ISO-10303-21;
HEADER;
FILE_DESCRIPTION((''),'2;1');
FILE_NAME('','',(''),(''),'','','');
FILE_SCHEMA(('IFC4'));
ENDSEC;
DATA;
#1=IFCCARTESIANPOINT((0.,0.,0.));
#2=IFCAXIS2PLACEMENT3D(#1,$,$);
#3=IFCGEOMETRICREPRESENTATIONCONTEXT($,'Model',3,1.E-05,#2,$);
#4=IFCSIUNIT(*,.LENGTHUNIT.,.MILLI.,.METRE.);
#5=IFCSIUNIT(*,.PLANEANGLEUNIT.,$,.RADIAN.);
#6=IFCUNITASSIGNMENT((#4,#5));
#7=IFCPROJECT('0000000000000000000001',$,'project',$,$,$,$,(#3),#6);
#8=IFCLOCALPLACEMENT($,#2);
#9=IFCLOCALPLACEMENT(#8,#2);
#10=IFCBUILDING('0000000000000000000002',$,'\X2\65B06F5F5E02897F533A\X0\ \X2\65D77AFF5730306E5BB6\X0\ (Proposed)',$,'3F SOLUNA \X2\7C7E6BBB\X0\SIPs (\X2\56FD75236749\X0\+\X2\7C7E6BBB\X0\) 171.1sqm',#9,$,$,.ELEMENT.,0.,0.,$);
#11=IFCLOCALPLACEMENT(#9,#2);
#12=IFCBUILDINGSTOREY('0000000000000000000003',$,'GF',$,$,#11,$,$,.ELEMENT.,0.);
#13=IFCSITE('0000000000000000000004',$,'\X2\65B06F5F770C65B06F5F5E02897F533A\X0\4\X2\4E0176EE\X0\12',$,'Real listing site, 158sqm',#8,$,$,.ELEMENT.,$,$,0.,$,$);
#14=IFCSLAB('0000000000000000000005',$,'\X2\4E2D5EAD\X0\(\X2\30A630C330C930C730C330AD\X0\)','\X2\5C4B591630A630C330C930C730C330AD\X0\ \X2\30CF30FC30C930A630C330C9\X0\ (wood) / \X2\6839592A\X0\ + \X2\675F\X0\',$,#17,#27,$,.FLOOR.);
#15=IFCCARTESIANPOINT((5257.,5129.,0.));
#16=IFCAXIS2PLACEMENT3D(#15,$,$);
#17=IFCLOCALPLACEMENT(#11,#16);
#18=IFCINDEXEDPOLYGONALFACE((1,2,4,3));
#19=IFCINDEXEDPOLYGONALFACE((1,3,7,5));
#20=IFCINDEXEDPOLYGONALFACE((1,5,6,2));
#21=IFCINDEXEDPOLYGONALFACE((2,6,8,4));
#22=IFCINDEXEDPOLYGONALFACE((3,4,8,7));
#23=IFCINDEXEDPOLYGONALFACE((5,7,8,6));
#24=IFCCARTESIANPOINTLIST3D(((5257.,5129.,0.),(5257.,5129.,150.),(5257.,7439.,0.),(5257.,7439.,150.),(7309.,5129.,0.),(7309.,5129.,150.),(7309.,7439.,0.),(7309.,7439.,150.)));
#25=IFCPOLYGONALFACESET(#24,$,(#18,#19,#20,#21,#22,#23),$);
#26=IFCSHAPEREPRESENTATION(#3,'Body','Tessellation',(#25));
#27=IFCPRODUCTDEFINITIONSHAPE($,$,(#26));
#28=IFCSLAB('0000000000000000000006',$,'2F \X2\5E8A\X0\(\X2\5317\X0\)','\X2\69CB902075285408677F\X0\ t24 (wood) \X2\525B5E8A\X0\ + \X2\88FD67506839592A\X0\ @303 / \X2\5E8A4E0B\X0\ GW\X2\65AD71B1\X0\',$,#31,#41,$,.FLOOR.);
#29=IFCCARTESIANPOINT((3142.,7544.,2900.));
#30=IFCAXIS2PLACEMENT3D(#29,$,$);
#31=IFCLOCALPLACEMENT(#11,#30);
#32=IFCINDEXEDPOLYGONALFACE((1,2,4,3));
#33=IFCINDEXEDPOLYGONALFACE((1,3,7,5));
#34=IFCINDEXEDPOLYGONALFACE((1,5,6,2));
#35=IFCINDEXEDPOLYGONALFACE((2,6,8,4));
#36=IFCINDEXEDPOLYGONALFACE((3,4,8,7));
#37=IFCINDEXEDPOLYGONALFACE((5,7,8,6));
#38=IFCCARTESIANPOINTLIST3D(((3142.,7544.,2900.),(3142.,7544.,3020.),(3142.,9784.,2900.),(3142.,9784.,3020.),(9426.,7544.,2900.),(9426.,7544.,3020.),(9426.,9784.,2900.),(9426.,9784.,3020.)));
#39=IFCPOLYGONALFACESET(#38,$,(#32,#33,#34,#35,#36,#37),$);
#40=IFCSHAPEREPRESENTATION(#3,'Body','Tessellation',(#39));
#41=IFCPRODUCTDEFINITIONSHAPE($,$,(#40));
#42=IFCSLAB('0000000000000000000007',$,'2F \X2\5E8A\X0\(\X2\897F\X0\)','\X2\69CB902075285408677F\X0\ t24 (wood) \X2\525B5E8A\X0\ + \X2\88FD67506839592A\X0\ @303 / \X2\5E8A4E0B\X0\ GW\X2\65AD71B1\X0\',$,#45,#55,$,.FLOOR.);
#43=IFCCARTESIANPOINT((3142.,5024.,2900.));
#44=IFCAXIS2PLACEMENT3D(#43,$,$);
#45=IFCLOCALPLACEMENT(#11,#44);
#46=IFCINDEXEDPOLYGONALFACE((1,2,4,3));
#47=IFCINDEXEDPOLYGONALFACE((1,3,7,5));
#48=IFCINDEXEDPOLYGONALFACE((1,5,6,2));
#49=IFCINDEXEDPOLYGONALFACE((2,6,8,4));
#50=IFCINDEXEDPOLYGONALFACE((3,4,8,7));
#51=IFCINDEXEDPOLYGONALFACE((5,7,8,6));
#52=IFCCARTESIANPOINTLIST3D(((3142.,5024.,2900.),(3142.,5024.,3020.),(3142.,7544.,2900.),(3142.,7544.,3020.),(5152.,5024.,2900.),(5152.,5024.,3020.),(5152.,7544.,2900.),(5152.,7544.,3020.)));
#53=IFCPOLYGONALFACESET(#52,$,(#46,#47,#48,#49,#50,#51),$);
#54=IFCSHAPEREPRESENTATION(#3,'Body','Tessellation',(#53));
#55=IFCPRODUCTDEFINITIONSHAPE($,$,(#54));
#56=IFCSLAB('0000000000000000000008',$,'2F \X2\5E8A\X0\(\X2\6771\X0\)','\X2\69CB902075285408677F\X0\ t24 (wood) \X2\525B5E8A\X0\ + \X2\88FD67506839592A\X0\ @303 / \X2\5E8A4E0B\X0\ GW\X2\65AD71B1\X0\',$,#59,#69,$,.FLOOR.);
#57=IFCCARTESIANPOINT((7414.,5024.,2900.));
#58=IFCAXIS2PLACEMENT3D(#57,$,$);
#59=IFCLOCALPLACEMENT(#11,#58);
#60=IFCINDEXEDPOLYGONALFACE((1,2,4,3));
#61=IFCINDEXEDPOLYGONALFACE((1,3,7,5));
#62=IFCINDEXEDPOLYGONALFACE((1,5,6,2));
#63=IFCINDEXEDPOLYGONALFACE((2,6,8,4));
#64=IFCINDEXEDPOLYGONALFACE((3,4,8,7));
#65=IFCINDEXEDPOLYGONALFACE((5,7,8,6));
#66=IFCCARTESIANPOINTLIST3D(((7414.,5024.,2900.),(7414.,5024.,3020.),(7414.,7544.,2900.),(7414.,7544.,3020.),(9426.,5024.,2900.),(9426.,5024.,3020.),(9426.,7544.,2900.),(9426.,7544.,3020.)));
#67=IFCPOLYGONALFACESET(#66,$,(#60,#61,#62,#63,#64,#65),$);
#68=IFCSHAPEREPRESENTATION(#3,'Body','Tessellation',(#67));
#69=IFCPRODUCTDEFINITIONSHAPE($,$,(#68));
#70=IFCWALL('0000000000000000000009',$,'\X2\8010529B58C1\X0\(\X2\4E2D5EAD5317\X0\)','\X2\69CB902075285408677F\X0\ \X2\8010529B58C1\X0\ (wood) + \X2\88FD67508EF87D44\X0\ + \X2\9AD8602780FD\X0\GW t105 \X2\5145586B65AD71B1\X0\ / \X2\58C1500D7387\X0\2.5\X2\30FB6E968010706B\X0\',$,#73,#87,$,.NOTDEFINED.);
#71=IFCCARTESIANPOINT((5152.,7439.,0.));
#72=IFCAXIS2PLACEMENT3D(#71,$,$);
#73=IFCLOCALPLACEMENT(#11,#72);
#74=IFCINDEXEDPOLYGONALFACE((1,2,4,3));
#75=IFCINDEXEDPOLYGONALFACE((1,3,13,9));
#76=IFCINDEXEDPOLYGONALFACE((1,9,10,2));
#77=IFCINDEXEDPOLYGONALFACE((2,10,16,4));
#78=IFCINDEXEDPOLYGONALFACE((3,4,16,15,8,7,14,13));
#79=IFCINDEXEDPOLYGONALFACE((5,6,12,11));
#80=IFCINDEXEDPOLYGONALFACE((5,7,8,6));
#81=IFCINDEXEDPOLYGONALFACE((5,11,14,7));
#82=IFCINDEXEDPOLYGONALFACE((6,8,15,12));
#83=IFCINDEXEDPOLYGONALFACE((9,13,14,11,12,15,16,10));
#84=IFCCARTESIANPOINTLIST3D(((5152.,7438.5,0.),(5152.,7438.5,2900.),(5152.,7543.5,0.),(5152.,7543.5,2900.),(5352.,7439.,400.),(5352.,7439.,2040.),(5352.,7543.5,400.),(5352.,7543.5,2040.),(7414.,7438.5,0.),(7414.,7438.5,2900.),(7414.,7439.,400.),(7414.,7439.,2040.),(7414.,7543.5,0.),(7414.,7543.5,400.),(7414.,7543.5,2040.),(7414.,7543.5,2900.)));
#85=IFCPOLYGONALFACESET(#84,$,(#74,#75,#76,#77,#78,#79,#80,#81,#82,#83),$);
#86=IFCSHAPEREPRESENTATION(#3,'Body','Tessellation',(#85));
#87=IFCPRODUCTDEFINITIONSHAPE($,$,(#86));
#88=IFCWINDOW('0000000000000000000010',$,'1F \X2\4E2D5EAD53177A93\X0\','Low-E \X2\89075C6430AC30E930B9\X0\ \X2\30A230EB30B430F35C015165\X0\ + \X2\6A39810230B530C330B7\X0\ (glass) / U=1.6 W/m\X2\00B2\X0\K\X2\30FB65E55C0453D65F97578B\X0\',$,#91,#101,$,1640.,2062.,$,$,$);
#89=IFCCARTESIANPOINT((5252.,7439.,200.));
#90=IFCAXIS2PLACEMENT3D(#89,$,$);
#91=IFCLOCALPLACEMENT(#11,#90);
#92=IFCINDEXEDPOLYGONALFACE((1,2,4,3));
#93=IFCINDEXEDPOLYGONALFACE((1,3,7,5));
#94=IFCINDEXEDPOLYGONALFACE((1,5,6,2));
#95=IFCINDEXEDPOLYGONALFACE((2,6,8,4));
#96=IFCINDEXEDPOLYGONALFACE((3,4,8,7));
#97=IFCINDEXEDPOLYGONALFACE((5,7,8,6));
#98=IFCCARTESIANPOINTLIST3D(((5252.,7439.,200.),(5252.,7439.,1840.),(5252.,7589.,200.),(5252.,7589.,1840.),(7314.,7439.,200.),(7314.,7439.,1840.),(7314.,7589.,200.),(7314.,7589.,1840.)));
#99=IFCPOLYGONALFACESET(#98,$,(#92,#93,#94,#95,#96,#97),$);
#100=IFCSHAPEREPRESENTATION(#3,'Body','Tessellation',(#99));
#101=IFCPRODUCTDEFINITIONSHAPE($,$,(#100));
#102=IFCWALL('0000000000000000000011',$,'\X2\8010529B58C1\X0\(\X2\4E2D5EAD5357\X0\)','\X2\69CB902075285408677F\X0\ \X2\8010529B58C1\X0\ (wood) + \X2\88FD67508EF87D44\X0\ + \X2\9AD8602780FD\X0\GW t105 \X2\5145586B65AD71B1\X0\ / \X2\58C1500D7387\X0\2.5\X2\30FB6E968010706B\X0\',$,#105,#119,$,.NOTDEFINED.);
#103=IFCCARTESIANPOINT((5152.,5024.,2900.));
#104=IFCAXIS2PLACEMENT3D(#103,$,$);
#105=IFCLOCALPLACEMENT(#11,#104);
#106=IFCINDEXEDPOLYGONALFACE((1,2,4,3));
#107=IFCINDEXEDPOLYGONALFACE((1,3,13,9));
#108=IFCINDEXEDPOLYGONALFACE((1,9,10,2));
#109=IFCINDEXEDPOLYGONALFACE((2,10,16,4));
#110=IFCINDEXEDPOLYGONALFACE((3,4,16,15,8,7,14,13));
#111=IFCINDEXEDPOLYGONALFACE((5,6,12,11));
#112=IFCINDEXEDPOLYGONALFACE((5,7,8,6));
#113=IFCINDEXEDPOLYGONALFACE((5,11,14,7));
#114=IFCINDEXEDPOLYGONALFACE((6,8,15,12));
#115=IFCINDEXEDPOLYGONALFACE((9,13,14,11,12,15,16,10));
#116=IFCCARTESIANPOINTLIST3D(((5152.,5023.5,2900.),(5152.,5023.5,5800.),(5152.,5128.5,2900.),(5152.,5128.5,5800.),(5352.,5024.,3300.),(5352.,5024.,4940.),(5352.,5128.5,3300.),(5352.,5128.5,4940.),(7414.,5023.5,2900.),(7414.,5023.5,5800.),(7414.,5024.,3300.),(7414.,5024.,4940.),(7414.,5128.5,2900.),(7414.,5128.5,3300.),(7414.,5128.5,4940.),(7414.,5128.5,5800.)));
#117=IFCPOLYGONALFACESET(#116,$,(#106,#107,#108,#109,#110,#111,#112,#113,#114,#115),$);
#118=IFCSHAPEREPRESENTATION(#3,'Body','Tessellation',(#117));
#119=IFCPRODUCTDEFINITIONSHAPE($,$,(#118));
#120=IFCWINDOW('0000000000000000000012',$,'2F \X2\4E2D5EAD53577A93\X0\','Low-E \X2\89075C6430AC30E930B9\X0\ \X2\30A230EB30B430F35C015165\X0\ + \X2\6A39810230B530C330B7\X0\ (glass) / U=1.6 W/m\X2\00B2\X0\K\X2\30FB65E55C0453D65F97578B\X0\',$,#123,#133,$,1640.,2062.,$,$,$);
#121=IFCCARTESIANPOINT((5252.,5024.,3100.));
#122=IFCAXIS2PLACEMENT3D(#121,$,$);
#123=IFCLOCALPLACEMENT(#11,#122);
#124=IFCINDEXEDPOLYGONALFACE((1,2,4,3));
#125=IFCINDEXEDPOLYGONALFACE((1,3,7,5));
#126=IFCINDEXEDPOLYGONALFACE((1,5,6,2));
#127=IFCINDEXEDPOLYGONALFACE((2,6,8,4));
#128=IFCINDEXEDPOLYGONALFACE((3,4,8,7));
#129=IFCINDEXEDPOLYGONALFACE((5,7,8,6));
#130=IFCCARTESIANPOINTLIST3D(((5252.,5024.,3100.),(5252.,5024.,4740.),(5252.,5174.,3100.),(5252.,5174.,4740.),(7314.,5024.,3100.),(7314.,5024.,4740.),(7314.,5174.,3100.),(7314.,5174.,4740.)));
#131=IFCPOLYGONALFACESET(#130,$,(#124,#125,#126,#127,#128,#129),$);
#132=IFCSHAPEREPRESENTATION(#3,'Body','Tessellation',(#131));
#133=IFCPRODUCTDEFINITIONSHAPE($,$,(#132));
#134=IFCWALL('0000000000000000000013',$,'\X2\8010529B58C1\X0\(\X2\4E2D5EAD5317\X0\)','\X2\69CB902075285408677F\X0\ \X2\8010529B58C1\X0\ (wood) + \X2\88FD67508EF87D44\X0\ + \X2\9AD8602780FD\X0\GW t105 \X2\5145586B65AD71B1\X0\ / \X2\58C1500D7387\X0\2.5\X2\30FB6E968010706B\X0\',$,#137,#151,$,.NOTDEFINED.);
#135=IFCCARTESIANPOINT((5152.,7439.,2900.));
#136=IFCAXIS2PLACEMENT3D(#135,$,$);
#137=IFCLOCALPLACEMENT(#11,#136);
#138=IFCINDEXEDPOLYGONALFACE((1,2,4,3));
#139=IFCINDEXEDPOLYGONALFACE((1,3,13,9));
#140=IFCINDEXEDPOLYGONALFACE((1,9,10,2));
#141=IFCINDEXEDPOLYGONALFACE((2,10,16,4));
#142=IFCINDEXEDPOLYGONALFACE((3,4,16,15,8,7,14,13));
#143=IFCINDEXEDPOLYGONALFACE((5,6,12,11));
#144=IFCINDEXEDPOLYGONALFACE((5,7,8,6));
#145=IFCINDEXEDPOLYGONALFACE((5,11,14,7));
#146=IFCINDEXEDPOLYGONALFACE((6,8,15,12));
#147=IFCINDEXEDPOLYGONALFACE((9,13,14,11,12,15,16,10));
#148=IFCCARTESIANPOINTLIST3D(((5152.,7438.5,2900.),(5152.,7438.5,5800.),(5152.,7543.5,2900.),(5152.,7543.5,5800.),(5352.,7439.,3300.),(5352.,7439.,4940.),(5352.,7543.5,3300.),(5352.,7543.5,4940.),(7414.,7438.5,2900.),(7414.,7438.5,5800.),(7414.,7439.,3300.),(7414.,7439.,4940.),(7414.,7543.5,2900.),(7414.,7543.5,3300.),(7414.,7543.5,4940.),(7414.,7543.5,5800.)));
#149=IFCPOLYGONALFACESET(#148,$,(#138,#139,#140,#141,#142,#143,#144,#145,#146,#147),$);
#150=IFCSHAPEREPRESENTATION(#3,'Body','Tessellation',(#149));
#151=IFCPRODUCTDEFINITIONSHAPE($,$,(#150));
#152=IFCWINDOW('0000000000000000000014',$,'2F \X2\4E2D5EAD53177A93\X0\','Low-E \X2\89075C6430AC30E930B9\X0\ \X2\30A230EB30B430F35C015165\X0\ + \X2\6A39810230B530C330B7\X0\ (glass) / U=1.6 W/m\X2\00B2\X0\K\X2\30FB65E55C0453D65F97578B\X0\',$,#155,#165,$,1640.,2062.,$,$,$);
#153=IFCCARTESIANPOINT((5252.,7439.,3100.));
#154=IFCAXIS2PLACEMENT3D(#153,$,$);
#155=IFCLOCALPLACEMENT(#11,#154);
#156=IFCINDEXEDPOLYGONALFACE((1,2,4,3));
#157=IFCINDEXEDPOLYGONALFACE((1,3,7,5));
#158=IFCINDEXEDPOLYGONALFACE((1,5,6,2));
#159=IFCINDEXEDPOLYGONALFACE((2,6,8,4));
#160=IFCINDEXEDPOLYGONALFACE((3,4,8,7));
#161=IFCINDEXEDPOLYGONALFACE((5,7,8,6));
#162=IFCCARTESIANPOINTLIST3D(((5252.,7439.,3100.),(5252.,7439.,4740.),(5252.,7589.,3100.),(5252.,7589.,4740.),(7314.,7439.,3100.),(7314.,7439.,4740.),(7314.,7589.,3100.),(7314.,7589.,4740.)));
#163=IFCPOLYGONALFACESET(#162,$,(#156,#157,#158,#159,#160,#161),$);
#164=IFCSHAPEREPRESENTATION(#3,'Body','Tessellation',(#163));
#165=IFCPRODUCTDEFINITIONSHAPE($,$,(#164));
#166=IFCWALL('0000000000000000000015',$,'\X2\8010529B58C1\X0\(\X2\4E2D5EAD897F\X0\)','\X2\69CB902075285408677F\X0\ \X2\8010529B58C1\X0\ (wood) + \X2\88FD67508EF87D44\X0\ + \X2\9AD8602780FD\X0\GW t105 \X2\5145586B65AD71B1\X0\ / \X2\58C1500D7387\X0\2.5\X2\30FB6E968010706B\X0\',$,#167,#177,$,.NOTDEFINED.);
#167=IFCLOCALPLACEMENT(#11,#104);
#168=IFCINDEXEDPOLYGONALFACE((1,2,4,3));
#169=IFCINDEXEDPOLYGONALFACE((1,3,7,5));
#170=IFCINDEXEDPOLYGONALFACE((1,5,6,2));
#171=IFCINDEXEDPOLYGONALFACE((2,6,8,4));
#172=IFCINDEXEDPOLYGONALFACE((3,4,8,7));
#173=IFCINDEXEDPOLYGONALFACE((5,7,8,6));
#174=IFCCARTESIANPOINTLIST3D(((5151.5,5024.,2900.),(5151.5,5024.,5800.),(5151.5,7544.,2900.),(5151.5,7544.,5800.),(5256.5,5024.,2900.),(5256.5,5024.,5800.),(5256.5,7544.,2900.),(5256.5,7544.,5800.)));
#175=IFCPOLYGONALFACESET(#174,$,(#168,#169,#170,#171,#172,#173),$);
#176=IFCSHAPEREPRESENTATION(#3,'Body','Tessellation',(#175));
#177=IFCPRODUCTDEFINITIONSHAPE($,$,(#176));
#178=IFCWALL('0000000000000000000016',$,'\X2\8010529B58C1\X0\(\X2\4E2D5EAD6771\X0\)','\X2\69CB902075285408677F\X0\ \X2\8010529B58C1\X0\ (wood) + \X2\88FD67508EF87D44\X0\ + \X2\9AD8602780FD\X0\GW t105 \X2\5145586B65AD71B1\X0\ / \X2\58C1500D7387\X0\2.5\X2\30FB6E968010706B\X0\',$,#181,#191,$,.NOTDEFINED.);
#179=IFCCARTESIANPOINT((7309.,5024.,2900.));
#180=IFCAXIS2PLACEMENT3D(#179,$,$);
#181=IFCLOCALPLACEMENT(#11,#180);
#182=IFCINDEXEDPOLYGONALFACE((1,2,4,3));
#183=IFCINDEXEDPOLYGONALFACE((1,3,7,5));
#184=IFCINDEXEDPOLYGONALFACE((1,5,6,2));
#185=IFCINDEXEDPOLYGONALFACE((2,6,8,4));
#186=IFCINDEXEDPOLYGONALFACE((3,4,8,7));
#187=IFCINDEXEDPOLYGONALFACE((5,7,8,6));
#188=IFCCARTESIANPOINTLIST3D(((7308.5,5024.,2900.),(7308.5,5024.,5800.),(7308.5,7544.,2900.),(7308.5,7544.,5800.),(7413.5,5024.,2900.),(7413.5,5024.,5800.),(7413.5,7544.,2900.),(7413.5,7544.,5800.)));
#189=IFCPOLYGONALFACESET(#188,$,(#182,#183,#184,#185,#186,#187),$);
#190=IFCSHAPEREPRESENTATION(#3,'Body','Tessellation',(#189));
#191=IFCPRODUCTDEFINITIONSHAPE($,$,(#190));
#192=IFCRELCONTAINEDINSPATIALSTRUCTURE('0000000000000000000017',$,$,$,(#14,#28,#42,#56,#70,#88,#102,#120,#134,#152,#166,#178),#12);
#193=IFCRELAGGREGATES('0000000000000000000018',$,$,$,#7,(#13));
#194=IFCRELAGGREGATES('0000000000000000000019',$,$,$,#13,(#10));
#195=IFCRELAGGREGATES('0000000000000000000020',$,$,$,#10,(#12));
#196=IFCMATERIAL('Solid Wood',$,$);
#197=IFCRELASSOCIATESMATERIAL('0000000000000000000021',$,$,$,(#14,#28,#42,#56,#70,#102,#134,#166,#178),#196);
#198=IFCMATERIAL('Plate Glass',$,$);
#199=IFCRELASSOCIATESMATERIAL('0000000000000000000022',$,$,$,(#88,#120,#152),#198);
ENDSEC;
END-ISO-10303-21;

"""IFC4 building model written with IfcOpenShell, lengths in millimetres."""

from ifc_helpers import new_model, si_unit, frame, frame_2d, origin, place, context, project, spatial, rectangle, extrude, material, element, fill, save


model = new_model("IFC4")

# Units and contexts
model_context = context("Model", 3, precision=1e-05, world=origin())
ifc_project = project(units=[si_unit("LENGTHUNIT", "METRE", prefix="MILLI"), si_unit("PLANEANGLEUNIT", "RADIAN")], contexts=[model_context])

# Site, building, storey
site_placement = place(None, origin())
site = spatial("IfcSite", under=ifc_project, at=site_placement, Name="新潟県新潟市西区4丁目12", ObjectType="Real listing site, 158sqm", CompositionType="ELEMENT", RefElevation=0.0)
building_placement = place(site_placement, origin())
building = spatial("IfcBuilding", under=site, at=building_placement, Name="新潟市西区 旗竿地の家 (Proposed)", ObjectType="3F SOLUNA 籾殻SIPs (国産杉+籾殻) 171.1sqm", CompositionType="ELEMENT", ElevationOfRefHeight=0.0, ElevationOfTerrain=0.0)
storey_placement = place(building_placement, origin())
storey = spatial("IfcBuildingStorey", under=building, at=storey_placement, Name="GF", CompositionType="ELEMENT", Elevation=0.0)

# Slabs
ifc_material_1 = material(Name="Solid Wood")
slab_1_placement = place(storey_placement, frame((5257.0, 5129.0, 0.0)))
element("IfcSlab", 1, at=slab_1_placement, inside=storey, material=ifc_material_1, Name="中庭(ウッドデッキ)", Description="屋外ウッドデッキ ハードウッド (wood) / 根太 + 束", PredefinedType="FLOOR", context=model_context, shape_type="SweptSolid", body=[
    extrude(rectangle(XDim=2052.0, YDim=2310.0, at=frame_2d((1026.0, 1155.0))), frame((5257.0, 5129.0, 0.0)), (0.0, 0.0, 1.0), 150.0),
])
slab_2_placement = place(storey_placement, frame((3142.0, 7544.0, 2900.0)))
element("IfcSlab", 2, at=slab_2_placement, inside=storey, material=ifc_material_1, Name="2F 床(北)", Description="構造用合板 t24 (wood) 剛床 + 製材根太 @303 / 床下 GW断熱", PredefinedType="FLOOR", context=model_context, shape_type="SweptSolid", body=[
    extrude(rectangle(XDim=6284.0, YDim=2240.0, at=frame_2d((3142.0, 1120.0))), frame((3142.0, 7544.0, 2900.0)), (0.0, 0.0, 1.0), 120.0),
])
slab_3_placement = place(storey_placement, frame((3142.0, 5024.0, 2900.0)))
element("IfcSlab", 3, at=slab_3_placement, inside=storey, material=ifc_material_1, Name="2F 床(西)", Description="構造用合板 t24 (wood) 剛床 + 製材根太 @303 / 床下 GW断熱", PredefinedType="FLOOR", context=model_context, shape_type="SweptSolid", body=[
    extrude(rectangle(XDim=2010.0, YDim=2520.0, at=frame_2d((1005.0, 1260.0))), frame((3142.0, 5024.0, 2900.0)), (0.0, 0.0, 1.0), 120.0),
])
slab_4_placement = place(storey_placement, frame((7414.0, 5024.0, 2900.0)))
element("IfcSlab", 4, at=slab_4_placement, inside=storey, material=ifc_material_1, Name="2F 床(東)", Description="構造用合板 t24 (wood) 剛床 + 製材根太 @303 / 床下 GW断熱", PredefinedType="FLOOR", context=model_context, shape_type="SweptSolid", body=[
    extrude(rectangle(XDim=2012.0, YDim=2520.0, at=frame_2d((1006.0, 1260.0))), frame((7414.0, 5024.0, 2900.0)), (0.0, 0.0, 1.0), 120.0),
])

# Wall, opening, window
wall_1_placement = place(storey_placement, frame((5152.0, 7439.0, 0.0)))
wall_1 = element("IfcWall", 5, at=wall_1_placement, inside=storey, material=ifc_material_1, Name="耐力壁(中庭北)", Description="構造用合板 耐力壁 (wood) + 製材軸組 + 高性能GW t105 充填断熱 / 壁倍率2.5・準耐火", PredefinedType="NOTDEFINED", context=model_context, shape_type="SweptSolid", body=[
    extrude(rectangle(XDim=2262.0, YDim=105.0, at=frame_2d((1131.0, 52.0))), frame((5152.0, 7439.0, 0.0)), (0.0, 0.0, 1.0), 2900.0),
])
opening_1_placement = place(storey_placement, frame((5252.0, 7439.0, 200.0)))
opening_1 = element("IfcOpeningElement", 6, at=opening_1_placement, cuts=wall_1, PredefinedType="NOTDEFINED", context=model_context, shape_type="SweptSolid", body=[
    extrude(rectangle(XDim=2062.0, YDim=150.0, at=frame_2d((1031.0, 75.0))), frame((5252.0, 7439.0, 200.0)), (0.0, 0.0, 1.0), 1640.0),
])
ifc_material_2 = material(Name="Plate Glass")
window_1_placement = place(storey_placement, frame((5252.0, 7439.0, 200.0)))
window_1 = element("IfcWindow", 7, at=window_1_placement, inside=storey, material=ifc_material_2, Name="1F 中庭北窓", Description="Low-E 複層ガラス アルゴン封入 + 樹脂サッシ (glass) / U=1.6 W/m²K・日射取得型", OverallHeight=1640.0, OverallWidth=2062.0, context=model_context, shape_type="SweptSolid", body=[
    extrude(rectangle(XDim=2062.0, YDim=150.0, at=frame_2d((1031.0, 75.0))), frame((5252.0, 7439.0, 200.0)), (0.0, 0.0, 1.0), 1640.0),
])
fill(opening_1, window_1)

# Walls, openings, windows
wall_2_placement = place(storey_placement, frame((5152.0, 5024.0, 2900.0)))
wall_2 = element("IfcWall", 8, at=wall_2_placement, inside=storey, material=ifc_material_1, Name="耐力壁(中庭南)", Description="構造用合板 耐力壁 (wood) + 製材軸組 + 高性能GW t105 充填断熱 / 壁倍率2.5・準耐火", PredefinedType="NOTDEFINED", context=model_context, shape_type="SweptSolid", body=[
    extrude(rectangle(XDim=2262.0, YDim=105.0, at=frame_2d((1131.0, 52.0))), frame((5152.0, 5024.0, 2900.0)), (0.0, 0.0, 1.0), 2900.0),
])
opening_2_placement = place(storey_placement, frame((5252.0, 5024.0, 3100.0)))
opening_2 = element("IfcOpeningElement", 9, at=opening_2_placement, cuts=wall_2, PredefinedType="NOTDEFINED", context=model_context, shape_type="SweptSolid", body=[
    extrude(rectangle(XDim=2062.0, YDim=150.0, at=frame_2d((1031.0, 75.0))), frame((5252.0, 5024.0, 3100.0)), (0.0, 0.0, 1.0), 1640.0),
])
window_2_placement = place(storey_placement, frame((5252.0, 5024.0, 3100.0)))
window_2 = element("IfcWindow", 10, at=window_2_placement, inside=storey, material=ifc_material_2, Name="2F 中庭南窓", Description="Low-E 複層ガラス アルゴン封入 + 樹脂サッシ (glass) / U=1.6 W/m²K・日射取得型", OverallHeight=1640.0, OverallWidth=2062.0, context=model_context, shape_type="SweptSolid", body=[
    extrude(rectangle(XDim=2062.0, YDim=150.0, at=frame_2d((1031.0, 75.0))), frame((5252.0, 5024.0, 3100.0)), (0.0, 0.0, 1.0), 1640.0),
])
fill(opening_2, window_2)
wall_3_placement = place(storey_placement, frame((5152.0, 7439.0, 2900.0)))
wall_3 = element("IfcWall", 11, at=wall_3_placement, inside=storey, material=ifc_material_1, Name="耐力壁(中庭北)", Description="構造用合板 耐力壁 (wood) + 製材軸組 + 高性能GW t105 充填断熱 / 壁倍率2.5・準耐火", PredefinedType="NOTDEFINED", context=model_context, shape_type="SweptSolid", body=[
    extrude(rectangle(XDim=2262.0, YDim=105.0, at=frame_2d((1131.0, 52.0))), frame((5152.0, 7439.0, 2900.0)), (0.0, 0.0, 1.0), 2900.0),
])
opening_3_placement = place(storey_placement, frame((5252.0, 7439.0, 3100.0)))
opening_3 = element("IfcOpeningElement", 12, at=opening_3_placement, cuts=wall_3, PredefinedType="NOTDEFINED", context=model_context, shape_type="SweptSolid", body=[
    extrude(rectangle(XDim=2062.0, YDim=150.0, at=frame_2d((1031.0, 75.0))), frame((5252.0, 7439.0, 3100.0)), (0.0, 0.0, 1.0), 1640.0),
])
window_3_placement = place(storey_placement, frame((5252.0, 7439.0, 3100.0)))
window_3 = element("IfcWindow", 13, at=window_3_placement, inside=storey, material=ifc_material_2, Name="2F 中庭北窓", Description="Low-E 複層ガラス アルゴン封入 + 樹脂サッシ (glass) / U=1.6 W/m²K・日射取得型", OverallHeight=1640.0, OverallWidth=2062.0, context=model_context, shape_type="SweptSolid", body=[
    extrude(rectangle(XDim=2062.0, YDim=150.0, at=frame_2d((1031.0, 75.0))), frame((5252.0, 7439.0, 3100.0)), (0.0, 0.0, 1.0), 1640.0),
])
fill(opening_3, window_3)

# Walls
wall_4_placement = place(storey_placement, frame((5152.0, 5024.0, 2900.0)))
element("IfcWall", 14, at=wall_4_placement, inside=storey, material=ifc_material_1, Name="耐力壁(中庭西)", Description="構造用合板 耐力壁 (wood) + 製材軸組 + 高性能GW t105 充填断熱 / 壁倍率2.5・準耐火", PredefinedType="NOTDEFINED", context=model_context, shape_type="SweptSolid", body=[
    extrude(rectangle(XDim=105.0, YDim=2520.0, at=frame_2d((52.0, 1260.0))), frame((5152.0, 5024.0, 2900.0)), (0.0, 0.0, 1.0), 2900.0),
])
wall_5_placement = place(storey_placement, frame((7309.0, 5024.0, 2900.0)))
element("IfcWall", 15, at=wall_5_placement, inside=storey, material=ifc_material_1, Name="耐力壁(中庭東)", Description="構造用合板 耐力壁 (wood) + 製材軸組 + 高性能GW t105 充填断熱 / 壁倍率2.5・準耐火", PredefinedType="NOTDEFINED", context=model_context, shape_type="SweptSolid", body=[
    extrude(rectangle(XDim=105.0, YDim=2520.0, at=frame_2d((52.0, 1260.0))), frame((7309.0, 5024.0, 2900.0)), (0.0, 0.0, 1.0), 2900.0),
])

save(model, "model.ifc")
